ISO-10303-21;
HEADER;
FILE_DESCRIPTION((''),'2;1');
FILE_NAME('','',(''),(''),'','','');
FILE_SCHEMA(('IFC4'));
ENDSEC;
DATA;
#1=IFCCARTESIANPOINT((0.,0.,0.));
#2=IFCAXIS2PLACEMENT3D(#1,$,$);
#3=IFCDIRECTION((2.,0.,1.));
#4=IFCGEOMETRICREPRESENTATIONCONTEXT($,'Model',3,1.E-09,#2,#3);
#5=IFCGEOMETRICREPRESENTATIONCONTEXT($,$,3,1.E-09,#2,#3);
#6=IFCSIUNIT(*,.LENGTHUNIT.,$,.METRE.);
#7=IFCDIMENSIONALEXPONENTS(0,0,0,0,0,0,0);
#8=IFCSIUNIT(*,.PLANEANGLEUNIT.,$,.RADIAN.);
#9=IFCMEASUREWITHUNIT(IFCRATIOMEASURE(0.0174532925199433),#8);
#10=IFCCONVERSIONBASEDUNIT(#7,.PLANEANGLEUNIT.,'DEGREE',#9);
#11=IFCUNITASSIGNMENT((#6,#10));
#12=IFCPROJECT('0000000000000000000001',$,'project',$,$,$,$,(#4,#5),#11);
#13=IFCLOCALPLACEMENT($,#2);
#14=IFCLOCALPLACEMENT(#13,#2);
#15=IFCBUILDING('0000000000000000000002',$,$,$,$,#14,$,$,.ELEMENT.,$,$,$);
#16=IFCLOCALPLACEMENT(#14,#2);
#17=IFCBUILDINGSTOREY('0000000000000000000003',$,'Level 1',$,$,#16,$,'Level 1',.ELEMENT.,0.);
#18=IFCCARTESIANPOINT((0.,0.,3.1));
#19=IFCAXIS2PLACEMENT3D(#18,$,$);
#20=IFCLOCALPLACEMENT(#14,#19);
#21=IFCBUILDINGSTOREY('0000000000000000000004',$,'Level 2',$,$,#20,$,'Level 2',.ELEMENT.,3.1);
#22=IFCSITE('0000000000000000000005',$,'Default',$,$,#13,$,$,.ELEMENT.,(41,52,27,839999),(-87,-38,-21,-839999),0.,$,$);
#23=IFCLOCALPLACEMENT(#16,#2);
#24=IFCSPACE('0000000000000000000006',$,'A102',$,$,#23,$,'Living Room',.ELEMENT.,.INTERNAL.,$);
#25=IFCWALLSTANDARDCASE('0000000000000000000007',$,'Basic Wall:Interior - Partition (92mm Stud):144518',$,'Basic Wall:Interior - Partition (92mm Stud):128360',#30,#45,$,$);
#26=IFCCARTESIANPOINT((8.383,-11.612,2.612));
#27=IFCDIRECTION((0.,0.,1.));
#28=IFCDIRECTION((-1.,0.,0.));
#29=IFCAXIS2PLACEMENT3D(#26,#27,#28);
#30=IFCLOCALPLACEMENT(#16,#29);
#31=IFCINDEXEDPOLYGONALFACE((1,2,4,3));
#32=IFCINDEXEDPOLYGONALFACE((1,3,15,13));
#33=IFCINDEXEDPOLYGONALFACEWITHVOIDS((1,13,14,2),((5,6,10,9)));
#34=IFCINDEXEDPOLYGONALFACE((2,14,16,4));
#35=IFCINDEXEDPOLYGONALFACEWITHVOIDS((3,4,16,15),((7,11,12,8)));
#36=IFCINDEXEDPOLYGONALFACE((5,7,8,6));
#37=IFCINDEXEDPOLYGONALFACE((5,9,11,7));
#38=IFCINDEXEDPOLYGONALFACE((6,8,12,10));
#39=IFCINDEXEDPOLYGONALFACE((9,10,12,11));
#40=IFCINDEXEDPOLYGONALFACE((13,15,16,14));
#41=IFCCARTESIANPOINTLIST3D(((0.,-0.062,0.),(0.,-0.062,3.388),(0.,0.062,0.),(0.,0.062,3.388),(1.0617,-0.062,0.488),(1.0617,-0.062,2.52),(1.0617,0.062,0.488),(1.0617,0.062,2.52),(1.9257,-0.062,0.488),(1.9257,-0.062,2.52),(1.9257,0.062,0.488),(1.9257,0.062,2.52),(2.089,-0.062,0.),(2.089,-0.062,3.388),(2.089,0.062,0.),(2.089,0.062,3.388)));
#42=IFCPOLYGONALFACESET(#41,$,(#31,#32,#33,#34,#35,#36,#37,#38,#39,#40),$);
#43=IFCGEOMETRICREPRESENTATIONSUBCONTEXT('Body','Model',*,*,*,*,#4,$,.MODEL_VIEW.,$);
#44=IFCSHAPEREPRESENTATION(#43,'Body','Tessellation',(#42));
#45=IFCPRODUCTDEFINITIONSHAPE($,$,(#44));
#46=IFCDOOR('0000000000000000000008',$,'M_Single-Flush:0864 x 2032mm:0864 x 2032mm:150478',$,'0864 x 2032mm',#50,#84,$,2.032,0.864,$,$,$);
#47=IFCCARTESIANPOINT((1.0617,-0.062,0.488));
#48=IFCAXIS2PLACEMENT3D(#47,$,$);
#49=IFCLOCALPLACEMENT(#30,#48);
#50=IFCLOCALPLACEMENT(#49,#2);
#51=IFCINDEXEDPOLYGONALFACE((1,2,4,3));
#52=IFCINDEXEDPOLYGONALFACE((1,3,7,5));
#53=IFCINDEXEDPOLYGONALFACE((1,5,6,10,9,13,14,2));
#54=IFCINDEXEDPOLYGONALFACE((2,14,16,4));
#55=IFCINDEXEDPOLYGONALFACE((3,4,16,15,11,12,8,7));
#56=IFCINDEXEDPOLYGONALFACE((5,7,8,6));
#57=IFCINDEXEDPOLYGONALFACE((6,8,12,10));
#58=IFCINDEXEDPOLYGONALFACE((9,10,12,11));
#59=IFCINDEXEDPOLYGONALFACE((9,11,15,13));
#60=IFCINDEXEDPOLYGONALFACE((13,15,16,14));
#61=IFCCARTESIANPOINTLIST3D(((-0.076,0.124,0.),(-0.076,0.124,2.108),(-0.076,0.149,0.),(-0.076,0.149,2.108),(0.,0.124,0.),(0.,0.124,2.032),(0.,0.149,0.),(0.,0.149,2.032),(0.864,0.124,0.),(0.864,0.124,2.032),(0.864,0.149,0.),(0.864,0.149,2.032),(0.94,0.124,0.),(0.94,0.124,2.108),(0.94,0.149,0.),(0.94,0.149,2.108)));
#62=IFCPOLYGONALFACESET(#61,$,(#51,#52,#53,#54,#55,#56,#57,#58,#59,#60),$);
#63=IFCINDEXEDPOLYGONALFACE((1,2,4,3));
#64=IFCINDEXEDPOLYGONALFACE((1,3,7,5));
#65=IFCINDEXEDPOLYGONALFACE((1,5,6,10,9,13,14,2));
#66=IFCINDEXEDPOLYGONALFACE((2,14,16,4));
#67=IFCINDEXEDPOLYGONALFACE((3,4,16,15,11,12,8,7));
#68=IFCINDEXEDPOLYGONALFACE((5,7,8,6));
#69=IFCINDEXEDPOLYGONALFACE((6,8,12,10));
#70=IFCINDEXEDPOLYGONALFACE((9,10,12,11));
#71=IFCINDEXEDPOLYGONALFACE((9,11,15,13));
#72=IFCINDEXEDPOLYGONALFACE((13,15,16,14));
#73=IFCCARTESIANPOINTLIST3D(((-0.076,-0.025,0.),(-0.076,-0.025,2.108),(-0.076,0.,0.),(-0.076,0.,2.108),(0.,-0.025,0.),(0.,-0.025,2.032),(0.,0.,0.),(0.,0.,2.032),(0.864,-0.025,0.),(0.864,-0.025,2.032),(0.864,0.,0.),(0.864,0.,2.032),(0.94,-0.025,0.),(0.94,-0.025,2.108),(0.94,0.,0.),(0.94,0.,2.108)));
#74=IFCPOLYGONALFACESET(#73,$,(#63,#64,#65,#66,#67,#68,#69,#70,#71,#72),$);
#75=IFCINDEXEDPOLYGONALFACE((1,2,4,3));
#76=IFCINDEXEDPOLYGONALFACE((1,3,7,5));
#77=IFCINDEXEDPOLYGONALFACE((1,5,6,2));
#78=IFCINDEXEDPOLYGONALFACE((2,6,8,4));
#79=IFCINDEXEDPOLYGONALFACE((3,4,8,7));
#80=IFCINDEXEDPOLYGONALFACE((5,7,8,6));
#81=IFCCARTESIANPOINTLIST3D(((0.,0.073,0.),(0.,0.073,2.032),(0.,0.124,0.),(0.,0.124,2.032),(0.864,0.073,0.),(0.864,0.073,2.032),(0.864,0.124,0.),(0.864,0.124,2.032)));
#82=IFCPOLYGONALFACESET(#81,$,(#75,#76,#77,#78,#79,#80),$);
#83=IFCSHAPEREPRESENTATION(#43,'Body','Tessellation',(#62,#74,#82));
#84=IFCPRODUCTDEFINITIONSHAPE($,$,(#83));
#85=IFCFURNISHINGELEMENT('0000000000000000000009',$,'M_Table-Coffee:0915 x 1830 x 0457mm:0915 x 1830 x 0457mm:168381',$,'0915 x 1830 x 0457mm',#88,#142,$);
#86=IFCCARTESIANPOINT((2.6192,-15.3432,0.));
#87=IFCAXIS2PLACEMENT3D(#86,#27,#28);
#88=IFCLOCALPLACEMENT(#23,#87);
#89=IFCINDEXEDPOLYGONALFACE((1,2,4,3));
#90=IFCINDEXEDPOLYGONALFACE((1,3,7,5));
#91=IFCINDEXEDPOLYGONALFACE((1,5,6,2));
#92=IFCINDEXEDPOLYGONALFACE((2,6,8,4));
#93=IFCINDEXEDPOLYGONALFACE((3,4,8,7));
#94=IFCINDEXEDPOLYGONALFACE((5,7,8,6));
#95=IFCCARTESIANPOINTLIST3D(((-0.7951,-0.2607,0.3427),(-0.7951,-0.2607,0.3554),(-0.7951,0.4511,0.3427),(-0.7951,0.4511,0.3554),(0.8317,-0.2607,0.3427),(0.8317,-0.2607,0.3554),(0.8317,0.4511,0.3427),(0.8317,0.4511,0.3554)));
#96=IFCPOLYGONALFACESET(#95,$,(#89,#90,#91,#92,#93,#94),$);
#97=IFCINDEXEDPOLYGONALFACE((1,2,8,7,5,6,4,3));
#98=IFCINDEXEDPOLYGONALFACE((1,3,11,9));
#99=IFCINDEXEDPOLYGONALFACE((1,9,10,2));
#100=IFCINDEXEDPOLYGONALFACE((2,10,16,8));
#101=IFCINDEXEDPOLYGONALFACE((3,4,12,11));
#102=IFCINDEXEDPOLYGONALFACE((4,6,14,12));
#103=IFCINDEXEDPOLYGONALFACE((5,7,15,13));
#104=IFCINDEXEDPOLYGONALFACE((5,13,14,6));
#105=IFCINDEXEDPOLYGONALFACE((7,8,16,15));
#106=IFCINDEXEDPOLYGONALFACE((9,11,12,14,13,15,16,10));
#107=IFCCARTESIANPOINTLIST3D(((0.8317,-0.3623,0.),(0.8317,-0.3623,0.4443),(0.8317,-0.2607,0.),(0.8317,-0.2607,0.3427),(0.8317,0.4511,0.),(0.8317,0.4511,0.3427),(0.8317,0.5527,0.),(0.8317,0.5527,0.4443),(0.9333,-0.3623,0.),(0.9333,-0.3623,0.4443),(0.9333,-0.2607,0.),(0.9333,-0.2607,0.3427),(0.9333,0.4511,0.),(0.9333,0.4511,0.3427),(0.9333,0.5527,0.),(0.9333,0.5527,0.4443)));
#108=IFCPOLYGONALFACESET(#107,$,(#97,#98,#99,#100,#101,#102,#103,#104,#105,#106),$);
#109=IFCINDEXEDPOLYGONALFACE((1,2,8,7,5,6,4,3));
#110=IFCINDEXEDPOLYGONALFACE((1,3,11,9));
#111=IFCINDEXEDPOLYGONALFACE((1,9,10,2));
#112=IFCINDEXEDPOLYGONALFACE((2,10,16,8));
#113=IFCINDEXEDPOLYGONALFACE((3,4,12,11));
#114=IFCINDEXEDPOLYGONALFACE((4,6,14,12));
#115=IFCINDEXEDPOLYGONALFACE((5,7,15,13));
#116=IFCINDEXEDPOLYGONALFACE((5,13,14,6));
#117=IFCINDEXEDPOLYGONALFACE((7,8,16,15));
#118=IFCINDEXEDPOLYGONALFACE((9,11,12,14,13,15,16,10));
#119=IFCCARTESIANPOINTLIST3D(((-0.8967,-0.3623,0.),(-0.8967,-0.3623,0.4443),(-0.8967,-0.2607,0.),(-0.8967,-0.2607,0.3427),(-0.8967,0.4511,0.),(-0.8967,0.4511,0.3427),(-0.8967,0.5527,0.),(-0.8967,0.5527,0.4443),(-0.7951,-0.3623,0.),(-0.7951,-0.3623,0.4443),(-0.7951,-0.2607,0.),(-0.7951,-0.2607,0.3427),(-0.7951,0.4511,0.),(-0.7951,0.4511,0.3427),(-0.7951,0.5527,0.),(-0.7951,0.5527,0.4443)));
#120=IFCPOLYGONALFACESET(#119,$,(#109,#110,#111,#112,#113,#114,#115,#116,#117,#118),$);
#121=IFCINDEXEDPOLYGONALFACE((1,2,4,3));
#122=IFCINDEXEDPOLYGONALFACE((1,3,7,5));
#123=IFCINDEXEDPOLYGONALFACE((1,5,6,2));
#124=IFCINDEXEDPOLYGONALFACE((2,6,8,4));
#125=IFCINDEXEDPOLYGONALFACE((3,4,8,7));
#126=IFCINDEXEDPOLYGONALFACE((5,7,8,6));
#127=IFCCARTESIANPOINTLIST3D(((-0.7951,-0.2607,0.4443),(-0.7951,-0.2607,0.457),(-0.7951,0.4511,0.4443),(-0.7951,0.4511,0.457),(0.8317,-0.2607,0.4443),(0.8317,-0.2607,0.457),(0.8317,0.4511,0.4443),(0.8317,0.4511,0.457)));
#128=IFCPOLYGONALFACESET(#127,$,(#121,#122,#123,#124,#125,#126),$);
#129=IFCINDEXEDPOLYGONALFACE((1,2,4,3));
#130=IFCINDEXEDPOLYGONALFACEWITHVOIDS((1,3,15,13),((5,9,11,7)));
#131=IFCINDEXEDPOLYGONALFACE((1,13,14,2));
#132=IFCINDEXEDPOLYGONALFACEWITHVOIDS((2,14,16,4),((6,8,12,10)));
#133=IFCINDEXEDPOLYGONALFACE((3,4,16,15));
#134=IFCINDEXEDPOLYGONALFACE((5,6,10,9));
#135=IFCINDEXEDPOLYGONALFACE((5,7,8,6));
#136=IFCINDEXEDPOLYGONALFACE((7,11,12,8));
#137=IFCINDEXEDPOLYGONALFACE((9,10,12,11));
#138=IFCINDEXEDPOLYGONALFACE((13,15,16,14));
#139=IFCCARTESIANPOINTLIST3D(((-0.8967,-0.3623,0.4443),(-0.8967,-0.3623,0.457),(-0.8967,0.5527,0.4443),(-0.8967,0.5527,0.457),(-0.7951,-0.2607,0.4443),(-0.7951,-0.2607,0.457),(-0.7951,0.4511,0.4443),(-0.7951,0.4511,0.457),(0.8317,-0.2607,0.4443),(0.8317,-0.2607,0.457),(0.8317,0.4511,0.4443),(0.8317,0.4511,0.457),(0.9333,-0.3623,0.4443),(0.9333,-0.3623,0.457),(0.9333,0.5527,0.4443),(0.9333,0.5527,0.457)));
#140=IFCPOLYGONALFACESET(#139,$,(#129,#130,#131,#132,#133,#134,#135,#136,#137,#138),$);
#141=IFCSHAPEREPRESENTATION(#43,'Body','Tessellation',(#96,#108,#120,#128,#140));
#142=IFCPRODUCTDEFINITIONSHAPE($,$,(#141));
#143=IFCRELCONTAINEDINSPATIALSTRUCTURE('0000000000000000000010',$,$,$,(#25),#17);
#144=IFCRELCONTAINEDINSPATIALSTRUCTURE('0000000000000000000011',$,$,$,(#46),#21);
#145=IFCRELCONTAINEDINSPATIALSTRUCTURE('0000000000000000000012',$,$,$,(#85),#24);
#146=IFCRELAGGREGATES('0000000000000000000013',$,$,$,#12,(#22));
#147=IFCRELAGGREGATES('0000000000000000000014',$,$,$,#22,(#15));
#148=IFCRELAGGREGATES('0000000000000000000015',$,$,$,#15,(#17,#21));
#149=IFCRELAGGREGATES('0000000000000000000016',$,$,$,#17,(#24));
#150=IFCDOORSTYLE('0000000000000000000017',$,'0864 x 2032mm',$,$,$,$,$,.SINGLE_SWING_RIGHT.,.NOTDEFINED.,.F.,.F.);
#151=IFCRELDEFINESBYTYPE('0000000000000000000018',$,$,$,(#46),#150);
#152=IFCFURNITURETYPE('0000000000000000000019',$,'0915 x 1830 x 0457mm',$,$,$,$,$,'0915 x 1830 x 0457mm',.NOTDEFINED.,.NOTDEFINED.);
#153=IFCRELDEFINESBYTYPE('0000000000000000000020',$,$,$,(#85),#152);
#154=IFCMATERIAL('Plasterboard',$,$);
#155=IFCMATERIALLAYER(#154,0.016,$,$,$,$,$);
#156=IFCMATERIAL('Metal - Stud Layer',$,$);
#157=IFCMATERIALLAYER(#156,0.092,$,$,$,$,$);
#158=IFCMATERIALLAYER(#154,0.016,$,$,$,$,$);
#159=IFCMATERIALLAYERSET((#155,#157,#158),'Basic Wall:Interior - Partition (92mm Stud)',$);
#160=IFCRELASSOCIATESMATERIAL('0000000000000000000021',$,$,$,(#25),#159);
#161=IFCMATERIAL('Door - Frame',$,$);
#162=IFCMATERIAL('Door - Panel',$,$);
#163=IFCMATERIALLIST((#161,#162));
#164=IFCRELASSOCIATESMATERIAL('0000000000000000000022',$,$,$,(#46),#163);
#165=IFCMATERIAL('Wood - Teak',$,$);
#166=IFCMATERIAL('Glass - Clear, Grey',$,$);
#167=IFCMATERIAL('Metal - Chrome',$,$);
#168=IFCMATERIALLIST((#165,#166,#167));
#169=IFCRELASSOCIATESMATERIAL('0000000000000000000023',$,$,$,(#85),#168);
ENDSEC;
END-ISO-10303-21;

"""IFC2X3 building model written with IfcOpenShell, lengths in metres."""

from ifc_helpers import new_model, entity, si_unit, converted_unit, direction, frame, frame_2d, origin, origin_2d_with_axis, place, context, subcontext, project, spatial, polyline, rectangle, outline, extrude, source, transform, mapped, material, material_list, layer, layer_set, layer_usage, type_object, type_shapes, element, fill, save


model = new_model("IFC2X3")

# Units and contexts
model_context = context("Model", 3, precision=1e-09, world=origin(), true_north=direction((2.0, 0.0, 1.0)))
context_of_model = context(None, 3, precision=1e-09, world=origin(), true_north=direction((2.0, 0.0, 1.0)))
body_context = subcontext(model_context, "Body", "Model", "MODEL_VIEW")
ifc_project = project(units=[si_unit("LENGTHUNIT", "METRE"), converted_unit("PLANEANGLEUNIT", "DEGREE", entity("IfcRatioMeasure", 0.0174532925199433), si_unit("PLANEANGLEUNIT", "RADIAN"), dimensions=[0, 0, 0, 0, 0, 0, 0])], contexts=[model_context, context_of_model])

# Site, building, storey
site_placement = place(None, origin())
site = spatial("IfcSite", under=ifc_project, at=site_placement, Name="Default", CompositionType="ELEMENT", RefLatitude=(41, 52, 27, 839999), RefLongitude=(-87, -38, -21, -839999), RefElevation=0.0)
building_placement = place(site_placement, origin())
building = spatial("IfcBuilding", under=site, at=building_placement, CompositionType="ELEMENT")
storey_1_placement = place(building_placement, origin())
storey_1 = spatial("IfcBuildingStorey", under=building, at=storey_1_placement, Name="Level 1", LongName="Level 1", CompositionType="ELEMENT", Elevation=0.0)

# Shared definitions
ifc_material_1 = material(Name="Metal - Stud Layer")
ifc_material_2 = material(Name="Plasterboard")
ifc_material_3 = material(Name="Door - Frame")
ifc_material_4 = material(Name="Door - Panel")

# Shared definitions
ifc_layer_1 = layer(ifc_material_2, 0.016)
ifc_layer_2 = layer(ifc_material_1, 0.092)
ifc_layer_3 = layer(ifc_material_2, 0.016)
ifc_layer_set_1 = layer_set([ifc_layer_1, ifc_layer_2, ifc_layer_3], Name="Basic Wall:Interior - Partition (92mm Stud)")

# Wall, opening
ifc_layer_usage_1 = layer_usage(ifc_layer_set_1, "AXIS2", "NEGATIVE", 0.062)
wall_1_placement = place(storey_1_placement, frame((8.383, -11.612, 2.612), z_axis=(0.0, 0.0, 1.0), x_axis=(-1.0, 0.0, 0.0)))
wall_1 = element("IfcWallStandardCase", 1, at=wall_1_placement, inside=storey_1, material=ifc_layer_usage_1, Name="Basic Wall:Interior - Partition (92mm Stud):144518", ObjectType="Basic Wall:Interior - Partition (92mm Stud):128360", context=body_context, shape_type="SweptSolid", body=[
    extrude(rectangle(XDim=2.089, YDim=0.124, at=frame_2d((1.0445, 0.0), x_axis=(-1.0, 0.0))), origin(), (0.0, 0.0, 1.0), 3.388),
])
opening_1_placement = place(wall_1_placement, frame((1.0617, -0.062, 0.488)))
opening_1 = element("IfcOpeningElement", 2, at=opening_1_placement, cuts=wall_1, ObjectType="Opening", context=body_context, shape_type="SweptSolid", body=[
    extrude(rectangle(XDim=0.864, YDim=2.032, at=frame_2d((1.016, 0.432), x_axis=(0.0, 1.0))), frame((0.0, 0.0, 0.0), z_axis=(0.0, 1.0, 0.0), x_axis=(0.0, 0.0, 1.0)), (0.0, 0.0, 1.0), 0.124),
])

# Shared definitions
storey_2_placement = place(building_placement, frame((0.0, 0.0, 3.1)))
storey_2 = spatial("IfcBuildingStorey", under=building, at=storey_2_placement, Name="Level 2", LongName="Level 2", CompositionType="ELEMENT", Elevation=3.1)

# Door
ifc_material_list_1 = material_list([ifc_material_3, ifc_material_4])
door_style_1 = type_object("IfcDoorStyle", Name="0864 x 2032mm", ConstructionType="NOTDEFINED", OperationType="SINGLE_SWING_RIGHT", ParameterTakesPrecedence=False, Sizeable=False)
shared_shape_1 = source(origin(), body_context, "Body", "SweptSolid", [
    extrude(outline(polyline([(-0.508, -1.073), (0.508, -1.073), (0.508, 1.035), (0.432, 1.035), (0.432, -0.997), (-0.432, -0.997), (-0.432, 1.035), (-0.508, 1.035), (-0.508, -1.073)])), frame((0.432, 0.124, 1.035), z_axis=(0.0, 1.0, 0.0), x_axis=(1.0, 0.0, 0.0)), (0.0, 0.0, 1.0), 0.025),
    extrude(outline(polyline([(-1.073, -0.508), (1.035, -0.508), (1.035, -0.432), (-0.997, -0.432), (-0.997, 0.432), (1.035, 0.432), (1.035, 0.508), (-1.073, 0.508), (-1.073, -0.508)])), frame((0.432, -0.025, 1.035), z_axis=(0.0, 1.0, 0.0), x_axis=(0.0, 0.0, -1.0)), (0.0, 0.0, 1.0), 0.025),
    extrude(rectangle(XDim=0.051, YDim=0.864, at=origin_2d_with_axis()), frame((0.432, 0.0985, 0.0), z_axis=(0.0, 0.0, 1.0), x_axis=(0.0, 1.0, 0.0)), (0.0, 0.0, 1.0), 2.032),
])
type_shapes(door_style_1, [shared_shape_1])
door_1_placement = place(opening_1_placement, origin())
door_1 = element("IfcDoor", 3, at=door_1_placement, inside=storey_2, type_object=door_style_1, material=ifc_material_list_1, Name="M_Single-Flush:0864 x 2032mm:0864 x 2032mm:150478", ObjectType="0864 x 2032mm", OverallHeight=2.032, OverallWidth=0.864, context=body_context, shape_type="MappedRepresentation", body=[
    mapped(shared_shape_1, transform((0.0, 0.0, 0.0), scale=1.0)),
])
fill(opening_1, door_1)

# Shared definitions
space_1_placement = place(storey_1_placement, origin())
space_1 = spatial("IfcSpace", under=storey_1, at=space_1_placement, Name="A102", LongName="Living Room", CompositionType="ELEMENT", InteriorOrExteriorSpace="INTERNAL")

# Furnishing element
ifc_material_5 = material(Name="Wood - Teak")
ifc_material_6 = material(Name="Glass - Clear, Grey")
ifc_material_7 = material(Name="Metal - Chrome")
ifc_material_list_2 = material_list([ifc_material_5, ifc_material_6, ifc_material_7])
furniture_type_1 = type_object("IfcFurnitureType", Name="0915 x 1830 x 0457mm", ElementType="0915 x 1830 x 0457mm", AssemblyPlace="NOTDEFINED")
shared_shape_2 = source(origin(), body_context, "Body", "SweptSolid", [
    extrude(rectangle(XDim=1.6268, YDim=0.7118, at=origin_2d_with_axis()), frame((0.0183, 0.0952, 0.3427), z_axis=(0.0, 0.0, 1.0), x_axis=(-1.0, 0.0, 0.0)), (0.0, 0.0, 1.0), 0.0127),
    extrude(outline(polyline([(-0.1967, -0.4575), (0.2475, -0.4575), (0.2475, 0.4575), (-0.1967, 0.4575), (-0.1967, 0.3559), (0.146, 0.3559), (0.146, -0.3559), (-0.1967, -0.3559), (-0.1967, -0.4575)])), frame((0.8317, 0.0952, 0.1967), z_axis=(1.0, 0.0, 0.0), x_axis=(0.0, 0.0, 1.0)), (0.0, 0.0, 1.0), 0.1016),
    extrude(outline(polyline([(-0.4575, -0.2476), (0.4575, -0.2476), (0.4575, 0.1968), (0.3559, 0.1968), (0.3559, -0.1459), (-0.3559, -0.1459), (-0.3559, 0.1968), (-0.4575, 0.1968), (-0.4575, -0.2476)])), frame((-0.8967, 0.0952, 0.1968), z_axis=(1.0, 0.0, 0.0), x_axis=(0.0, -1.0, 0.0)), (0.0, 0.0, 1.0), 0.1016),
    extrude(rectangle(XDim=1.6268, YDim=0.7118, at=origin_2d_with_axis()), frame((0.0183, 0.0952, 0.4443), z_axis=(0.0, 0.0, 1.0), x_axis=(-1.0, 0.0, 0.0)), (0.0, 0.0, 1.0), 0.0127),
    extrude(outline(polyline([(-0.915, -0.4575), (0.915, -0.4575), (0.915, 0.4575), (-0.915, 0.4575), (-0.915, -0.4575)]), holes=[polyline([(-0.8134, -0.3559), (-0.8134, 0.3559), (0.8134, 0.3559), (0.8134, -0.3559), (-0.8134, -0.3559)])]), frame((0.0183, 0.0952, 0.4443), z_axis=(0.0, 0.0, 1.0), x_axis=(-1.0, 0.0, 0.0)), (0.0, 0.0, 1.0), 0.0127),
])
type_shapes(furniture_type_1, [shared_shape_2])
furnishing_1_placement = place(space_1_placement, frame((2.6192, -15.3432, 0.0), z_axis=(0.0, 0.0, 1.0), x_axis=(-1.0, 0.0, 0.0)))
element("IfcFurnishingElement", 4, at=furnishing_1_placement, inside=space_1, type_object=furniture_type_1, material=ifc_material_list_2, Name="M_Table-Coffee:0915 x 1830 x 0457mm:0915 x 1830 x 0457mm:168381", ObjectType="0915 x 1830 x 0457mm", context=body_context, shape_type="MappedRepresentation", body=[
    mapped(shared_shape_2, transform((0.0, 0.0, 0.0), scale=1.0)),
])

save(model, "model.ifc")
